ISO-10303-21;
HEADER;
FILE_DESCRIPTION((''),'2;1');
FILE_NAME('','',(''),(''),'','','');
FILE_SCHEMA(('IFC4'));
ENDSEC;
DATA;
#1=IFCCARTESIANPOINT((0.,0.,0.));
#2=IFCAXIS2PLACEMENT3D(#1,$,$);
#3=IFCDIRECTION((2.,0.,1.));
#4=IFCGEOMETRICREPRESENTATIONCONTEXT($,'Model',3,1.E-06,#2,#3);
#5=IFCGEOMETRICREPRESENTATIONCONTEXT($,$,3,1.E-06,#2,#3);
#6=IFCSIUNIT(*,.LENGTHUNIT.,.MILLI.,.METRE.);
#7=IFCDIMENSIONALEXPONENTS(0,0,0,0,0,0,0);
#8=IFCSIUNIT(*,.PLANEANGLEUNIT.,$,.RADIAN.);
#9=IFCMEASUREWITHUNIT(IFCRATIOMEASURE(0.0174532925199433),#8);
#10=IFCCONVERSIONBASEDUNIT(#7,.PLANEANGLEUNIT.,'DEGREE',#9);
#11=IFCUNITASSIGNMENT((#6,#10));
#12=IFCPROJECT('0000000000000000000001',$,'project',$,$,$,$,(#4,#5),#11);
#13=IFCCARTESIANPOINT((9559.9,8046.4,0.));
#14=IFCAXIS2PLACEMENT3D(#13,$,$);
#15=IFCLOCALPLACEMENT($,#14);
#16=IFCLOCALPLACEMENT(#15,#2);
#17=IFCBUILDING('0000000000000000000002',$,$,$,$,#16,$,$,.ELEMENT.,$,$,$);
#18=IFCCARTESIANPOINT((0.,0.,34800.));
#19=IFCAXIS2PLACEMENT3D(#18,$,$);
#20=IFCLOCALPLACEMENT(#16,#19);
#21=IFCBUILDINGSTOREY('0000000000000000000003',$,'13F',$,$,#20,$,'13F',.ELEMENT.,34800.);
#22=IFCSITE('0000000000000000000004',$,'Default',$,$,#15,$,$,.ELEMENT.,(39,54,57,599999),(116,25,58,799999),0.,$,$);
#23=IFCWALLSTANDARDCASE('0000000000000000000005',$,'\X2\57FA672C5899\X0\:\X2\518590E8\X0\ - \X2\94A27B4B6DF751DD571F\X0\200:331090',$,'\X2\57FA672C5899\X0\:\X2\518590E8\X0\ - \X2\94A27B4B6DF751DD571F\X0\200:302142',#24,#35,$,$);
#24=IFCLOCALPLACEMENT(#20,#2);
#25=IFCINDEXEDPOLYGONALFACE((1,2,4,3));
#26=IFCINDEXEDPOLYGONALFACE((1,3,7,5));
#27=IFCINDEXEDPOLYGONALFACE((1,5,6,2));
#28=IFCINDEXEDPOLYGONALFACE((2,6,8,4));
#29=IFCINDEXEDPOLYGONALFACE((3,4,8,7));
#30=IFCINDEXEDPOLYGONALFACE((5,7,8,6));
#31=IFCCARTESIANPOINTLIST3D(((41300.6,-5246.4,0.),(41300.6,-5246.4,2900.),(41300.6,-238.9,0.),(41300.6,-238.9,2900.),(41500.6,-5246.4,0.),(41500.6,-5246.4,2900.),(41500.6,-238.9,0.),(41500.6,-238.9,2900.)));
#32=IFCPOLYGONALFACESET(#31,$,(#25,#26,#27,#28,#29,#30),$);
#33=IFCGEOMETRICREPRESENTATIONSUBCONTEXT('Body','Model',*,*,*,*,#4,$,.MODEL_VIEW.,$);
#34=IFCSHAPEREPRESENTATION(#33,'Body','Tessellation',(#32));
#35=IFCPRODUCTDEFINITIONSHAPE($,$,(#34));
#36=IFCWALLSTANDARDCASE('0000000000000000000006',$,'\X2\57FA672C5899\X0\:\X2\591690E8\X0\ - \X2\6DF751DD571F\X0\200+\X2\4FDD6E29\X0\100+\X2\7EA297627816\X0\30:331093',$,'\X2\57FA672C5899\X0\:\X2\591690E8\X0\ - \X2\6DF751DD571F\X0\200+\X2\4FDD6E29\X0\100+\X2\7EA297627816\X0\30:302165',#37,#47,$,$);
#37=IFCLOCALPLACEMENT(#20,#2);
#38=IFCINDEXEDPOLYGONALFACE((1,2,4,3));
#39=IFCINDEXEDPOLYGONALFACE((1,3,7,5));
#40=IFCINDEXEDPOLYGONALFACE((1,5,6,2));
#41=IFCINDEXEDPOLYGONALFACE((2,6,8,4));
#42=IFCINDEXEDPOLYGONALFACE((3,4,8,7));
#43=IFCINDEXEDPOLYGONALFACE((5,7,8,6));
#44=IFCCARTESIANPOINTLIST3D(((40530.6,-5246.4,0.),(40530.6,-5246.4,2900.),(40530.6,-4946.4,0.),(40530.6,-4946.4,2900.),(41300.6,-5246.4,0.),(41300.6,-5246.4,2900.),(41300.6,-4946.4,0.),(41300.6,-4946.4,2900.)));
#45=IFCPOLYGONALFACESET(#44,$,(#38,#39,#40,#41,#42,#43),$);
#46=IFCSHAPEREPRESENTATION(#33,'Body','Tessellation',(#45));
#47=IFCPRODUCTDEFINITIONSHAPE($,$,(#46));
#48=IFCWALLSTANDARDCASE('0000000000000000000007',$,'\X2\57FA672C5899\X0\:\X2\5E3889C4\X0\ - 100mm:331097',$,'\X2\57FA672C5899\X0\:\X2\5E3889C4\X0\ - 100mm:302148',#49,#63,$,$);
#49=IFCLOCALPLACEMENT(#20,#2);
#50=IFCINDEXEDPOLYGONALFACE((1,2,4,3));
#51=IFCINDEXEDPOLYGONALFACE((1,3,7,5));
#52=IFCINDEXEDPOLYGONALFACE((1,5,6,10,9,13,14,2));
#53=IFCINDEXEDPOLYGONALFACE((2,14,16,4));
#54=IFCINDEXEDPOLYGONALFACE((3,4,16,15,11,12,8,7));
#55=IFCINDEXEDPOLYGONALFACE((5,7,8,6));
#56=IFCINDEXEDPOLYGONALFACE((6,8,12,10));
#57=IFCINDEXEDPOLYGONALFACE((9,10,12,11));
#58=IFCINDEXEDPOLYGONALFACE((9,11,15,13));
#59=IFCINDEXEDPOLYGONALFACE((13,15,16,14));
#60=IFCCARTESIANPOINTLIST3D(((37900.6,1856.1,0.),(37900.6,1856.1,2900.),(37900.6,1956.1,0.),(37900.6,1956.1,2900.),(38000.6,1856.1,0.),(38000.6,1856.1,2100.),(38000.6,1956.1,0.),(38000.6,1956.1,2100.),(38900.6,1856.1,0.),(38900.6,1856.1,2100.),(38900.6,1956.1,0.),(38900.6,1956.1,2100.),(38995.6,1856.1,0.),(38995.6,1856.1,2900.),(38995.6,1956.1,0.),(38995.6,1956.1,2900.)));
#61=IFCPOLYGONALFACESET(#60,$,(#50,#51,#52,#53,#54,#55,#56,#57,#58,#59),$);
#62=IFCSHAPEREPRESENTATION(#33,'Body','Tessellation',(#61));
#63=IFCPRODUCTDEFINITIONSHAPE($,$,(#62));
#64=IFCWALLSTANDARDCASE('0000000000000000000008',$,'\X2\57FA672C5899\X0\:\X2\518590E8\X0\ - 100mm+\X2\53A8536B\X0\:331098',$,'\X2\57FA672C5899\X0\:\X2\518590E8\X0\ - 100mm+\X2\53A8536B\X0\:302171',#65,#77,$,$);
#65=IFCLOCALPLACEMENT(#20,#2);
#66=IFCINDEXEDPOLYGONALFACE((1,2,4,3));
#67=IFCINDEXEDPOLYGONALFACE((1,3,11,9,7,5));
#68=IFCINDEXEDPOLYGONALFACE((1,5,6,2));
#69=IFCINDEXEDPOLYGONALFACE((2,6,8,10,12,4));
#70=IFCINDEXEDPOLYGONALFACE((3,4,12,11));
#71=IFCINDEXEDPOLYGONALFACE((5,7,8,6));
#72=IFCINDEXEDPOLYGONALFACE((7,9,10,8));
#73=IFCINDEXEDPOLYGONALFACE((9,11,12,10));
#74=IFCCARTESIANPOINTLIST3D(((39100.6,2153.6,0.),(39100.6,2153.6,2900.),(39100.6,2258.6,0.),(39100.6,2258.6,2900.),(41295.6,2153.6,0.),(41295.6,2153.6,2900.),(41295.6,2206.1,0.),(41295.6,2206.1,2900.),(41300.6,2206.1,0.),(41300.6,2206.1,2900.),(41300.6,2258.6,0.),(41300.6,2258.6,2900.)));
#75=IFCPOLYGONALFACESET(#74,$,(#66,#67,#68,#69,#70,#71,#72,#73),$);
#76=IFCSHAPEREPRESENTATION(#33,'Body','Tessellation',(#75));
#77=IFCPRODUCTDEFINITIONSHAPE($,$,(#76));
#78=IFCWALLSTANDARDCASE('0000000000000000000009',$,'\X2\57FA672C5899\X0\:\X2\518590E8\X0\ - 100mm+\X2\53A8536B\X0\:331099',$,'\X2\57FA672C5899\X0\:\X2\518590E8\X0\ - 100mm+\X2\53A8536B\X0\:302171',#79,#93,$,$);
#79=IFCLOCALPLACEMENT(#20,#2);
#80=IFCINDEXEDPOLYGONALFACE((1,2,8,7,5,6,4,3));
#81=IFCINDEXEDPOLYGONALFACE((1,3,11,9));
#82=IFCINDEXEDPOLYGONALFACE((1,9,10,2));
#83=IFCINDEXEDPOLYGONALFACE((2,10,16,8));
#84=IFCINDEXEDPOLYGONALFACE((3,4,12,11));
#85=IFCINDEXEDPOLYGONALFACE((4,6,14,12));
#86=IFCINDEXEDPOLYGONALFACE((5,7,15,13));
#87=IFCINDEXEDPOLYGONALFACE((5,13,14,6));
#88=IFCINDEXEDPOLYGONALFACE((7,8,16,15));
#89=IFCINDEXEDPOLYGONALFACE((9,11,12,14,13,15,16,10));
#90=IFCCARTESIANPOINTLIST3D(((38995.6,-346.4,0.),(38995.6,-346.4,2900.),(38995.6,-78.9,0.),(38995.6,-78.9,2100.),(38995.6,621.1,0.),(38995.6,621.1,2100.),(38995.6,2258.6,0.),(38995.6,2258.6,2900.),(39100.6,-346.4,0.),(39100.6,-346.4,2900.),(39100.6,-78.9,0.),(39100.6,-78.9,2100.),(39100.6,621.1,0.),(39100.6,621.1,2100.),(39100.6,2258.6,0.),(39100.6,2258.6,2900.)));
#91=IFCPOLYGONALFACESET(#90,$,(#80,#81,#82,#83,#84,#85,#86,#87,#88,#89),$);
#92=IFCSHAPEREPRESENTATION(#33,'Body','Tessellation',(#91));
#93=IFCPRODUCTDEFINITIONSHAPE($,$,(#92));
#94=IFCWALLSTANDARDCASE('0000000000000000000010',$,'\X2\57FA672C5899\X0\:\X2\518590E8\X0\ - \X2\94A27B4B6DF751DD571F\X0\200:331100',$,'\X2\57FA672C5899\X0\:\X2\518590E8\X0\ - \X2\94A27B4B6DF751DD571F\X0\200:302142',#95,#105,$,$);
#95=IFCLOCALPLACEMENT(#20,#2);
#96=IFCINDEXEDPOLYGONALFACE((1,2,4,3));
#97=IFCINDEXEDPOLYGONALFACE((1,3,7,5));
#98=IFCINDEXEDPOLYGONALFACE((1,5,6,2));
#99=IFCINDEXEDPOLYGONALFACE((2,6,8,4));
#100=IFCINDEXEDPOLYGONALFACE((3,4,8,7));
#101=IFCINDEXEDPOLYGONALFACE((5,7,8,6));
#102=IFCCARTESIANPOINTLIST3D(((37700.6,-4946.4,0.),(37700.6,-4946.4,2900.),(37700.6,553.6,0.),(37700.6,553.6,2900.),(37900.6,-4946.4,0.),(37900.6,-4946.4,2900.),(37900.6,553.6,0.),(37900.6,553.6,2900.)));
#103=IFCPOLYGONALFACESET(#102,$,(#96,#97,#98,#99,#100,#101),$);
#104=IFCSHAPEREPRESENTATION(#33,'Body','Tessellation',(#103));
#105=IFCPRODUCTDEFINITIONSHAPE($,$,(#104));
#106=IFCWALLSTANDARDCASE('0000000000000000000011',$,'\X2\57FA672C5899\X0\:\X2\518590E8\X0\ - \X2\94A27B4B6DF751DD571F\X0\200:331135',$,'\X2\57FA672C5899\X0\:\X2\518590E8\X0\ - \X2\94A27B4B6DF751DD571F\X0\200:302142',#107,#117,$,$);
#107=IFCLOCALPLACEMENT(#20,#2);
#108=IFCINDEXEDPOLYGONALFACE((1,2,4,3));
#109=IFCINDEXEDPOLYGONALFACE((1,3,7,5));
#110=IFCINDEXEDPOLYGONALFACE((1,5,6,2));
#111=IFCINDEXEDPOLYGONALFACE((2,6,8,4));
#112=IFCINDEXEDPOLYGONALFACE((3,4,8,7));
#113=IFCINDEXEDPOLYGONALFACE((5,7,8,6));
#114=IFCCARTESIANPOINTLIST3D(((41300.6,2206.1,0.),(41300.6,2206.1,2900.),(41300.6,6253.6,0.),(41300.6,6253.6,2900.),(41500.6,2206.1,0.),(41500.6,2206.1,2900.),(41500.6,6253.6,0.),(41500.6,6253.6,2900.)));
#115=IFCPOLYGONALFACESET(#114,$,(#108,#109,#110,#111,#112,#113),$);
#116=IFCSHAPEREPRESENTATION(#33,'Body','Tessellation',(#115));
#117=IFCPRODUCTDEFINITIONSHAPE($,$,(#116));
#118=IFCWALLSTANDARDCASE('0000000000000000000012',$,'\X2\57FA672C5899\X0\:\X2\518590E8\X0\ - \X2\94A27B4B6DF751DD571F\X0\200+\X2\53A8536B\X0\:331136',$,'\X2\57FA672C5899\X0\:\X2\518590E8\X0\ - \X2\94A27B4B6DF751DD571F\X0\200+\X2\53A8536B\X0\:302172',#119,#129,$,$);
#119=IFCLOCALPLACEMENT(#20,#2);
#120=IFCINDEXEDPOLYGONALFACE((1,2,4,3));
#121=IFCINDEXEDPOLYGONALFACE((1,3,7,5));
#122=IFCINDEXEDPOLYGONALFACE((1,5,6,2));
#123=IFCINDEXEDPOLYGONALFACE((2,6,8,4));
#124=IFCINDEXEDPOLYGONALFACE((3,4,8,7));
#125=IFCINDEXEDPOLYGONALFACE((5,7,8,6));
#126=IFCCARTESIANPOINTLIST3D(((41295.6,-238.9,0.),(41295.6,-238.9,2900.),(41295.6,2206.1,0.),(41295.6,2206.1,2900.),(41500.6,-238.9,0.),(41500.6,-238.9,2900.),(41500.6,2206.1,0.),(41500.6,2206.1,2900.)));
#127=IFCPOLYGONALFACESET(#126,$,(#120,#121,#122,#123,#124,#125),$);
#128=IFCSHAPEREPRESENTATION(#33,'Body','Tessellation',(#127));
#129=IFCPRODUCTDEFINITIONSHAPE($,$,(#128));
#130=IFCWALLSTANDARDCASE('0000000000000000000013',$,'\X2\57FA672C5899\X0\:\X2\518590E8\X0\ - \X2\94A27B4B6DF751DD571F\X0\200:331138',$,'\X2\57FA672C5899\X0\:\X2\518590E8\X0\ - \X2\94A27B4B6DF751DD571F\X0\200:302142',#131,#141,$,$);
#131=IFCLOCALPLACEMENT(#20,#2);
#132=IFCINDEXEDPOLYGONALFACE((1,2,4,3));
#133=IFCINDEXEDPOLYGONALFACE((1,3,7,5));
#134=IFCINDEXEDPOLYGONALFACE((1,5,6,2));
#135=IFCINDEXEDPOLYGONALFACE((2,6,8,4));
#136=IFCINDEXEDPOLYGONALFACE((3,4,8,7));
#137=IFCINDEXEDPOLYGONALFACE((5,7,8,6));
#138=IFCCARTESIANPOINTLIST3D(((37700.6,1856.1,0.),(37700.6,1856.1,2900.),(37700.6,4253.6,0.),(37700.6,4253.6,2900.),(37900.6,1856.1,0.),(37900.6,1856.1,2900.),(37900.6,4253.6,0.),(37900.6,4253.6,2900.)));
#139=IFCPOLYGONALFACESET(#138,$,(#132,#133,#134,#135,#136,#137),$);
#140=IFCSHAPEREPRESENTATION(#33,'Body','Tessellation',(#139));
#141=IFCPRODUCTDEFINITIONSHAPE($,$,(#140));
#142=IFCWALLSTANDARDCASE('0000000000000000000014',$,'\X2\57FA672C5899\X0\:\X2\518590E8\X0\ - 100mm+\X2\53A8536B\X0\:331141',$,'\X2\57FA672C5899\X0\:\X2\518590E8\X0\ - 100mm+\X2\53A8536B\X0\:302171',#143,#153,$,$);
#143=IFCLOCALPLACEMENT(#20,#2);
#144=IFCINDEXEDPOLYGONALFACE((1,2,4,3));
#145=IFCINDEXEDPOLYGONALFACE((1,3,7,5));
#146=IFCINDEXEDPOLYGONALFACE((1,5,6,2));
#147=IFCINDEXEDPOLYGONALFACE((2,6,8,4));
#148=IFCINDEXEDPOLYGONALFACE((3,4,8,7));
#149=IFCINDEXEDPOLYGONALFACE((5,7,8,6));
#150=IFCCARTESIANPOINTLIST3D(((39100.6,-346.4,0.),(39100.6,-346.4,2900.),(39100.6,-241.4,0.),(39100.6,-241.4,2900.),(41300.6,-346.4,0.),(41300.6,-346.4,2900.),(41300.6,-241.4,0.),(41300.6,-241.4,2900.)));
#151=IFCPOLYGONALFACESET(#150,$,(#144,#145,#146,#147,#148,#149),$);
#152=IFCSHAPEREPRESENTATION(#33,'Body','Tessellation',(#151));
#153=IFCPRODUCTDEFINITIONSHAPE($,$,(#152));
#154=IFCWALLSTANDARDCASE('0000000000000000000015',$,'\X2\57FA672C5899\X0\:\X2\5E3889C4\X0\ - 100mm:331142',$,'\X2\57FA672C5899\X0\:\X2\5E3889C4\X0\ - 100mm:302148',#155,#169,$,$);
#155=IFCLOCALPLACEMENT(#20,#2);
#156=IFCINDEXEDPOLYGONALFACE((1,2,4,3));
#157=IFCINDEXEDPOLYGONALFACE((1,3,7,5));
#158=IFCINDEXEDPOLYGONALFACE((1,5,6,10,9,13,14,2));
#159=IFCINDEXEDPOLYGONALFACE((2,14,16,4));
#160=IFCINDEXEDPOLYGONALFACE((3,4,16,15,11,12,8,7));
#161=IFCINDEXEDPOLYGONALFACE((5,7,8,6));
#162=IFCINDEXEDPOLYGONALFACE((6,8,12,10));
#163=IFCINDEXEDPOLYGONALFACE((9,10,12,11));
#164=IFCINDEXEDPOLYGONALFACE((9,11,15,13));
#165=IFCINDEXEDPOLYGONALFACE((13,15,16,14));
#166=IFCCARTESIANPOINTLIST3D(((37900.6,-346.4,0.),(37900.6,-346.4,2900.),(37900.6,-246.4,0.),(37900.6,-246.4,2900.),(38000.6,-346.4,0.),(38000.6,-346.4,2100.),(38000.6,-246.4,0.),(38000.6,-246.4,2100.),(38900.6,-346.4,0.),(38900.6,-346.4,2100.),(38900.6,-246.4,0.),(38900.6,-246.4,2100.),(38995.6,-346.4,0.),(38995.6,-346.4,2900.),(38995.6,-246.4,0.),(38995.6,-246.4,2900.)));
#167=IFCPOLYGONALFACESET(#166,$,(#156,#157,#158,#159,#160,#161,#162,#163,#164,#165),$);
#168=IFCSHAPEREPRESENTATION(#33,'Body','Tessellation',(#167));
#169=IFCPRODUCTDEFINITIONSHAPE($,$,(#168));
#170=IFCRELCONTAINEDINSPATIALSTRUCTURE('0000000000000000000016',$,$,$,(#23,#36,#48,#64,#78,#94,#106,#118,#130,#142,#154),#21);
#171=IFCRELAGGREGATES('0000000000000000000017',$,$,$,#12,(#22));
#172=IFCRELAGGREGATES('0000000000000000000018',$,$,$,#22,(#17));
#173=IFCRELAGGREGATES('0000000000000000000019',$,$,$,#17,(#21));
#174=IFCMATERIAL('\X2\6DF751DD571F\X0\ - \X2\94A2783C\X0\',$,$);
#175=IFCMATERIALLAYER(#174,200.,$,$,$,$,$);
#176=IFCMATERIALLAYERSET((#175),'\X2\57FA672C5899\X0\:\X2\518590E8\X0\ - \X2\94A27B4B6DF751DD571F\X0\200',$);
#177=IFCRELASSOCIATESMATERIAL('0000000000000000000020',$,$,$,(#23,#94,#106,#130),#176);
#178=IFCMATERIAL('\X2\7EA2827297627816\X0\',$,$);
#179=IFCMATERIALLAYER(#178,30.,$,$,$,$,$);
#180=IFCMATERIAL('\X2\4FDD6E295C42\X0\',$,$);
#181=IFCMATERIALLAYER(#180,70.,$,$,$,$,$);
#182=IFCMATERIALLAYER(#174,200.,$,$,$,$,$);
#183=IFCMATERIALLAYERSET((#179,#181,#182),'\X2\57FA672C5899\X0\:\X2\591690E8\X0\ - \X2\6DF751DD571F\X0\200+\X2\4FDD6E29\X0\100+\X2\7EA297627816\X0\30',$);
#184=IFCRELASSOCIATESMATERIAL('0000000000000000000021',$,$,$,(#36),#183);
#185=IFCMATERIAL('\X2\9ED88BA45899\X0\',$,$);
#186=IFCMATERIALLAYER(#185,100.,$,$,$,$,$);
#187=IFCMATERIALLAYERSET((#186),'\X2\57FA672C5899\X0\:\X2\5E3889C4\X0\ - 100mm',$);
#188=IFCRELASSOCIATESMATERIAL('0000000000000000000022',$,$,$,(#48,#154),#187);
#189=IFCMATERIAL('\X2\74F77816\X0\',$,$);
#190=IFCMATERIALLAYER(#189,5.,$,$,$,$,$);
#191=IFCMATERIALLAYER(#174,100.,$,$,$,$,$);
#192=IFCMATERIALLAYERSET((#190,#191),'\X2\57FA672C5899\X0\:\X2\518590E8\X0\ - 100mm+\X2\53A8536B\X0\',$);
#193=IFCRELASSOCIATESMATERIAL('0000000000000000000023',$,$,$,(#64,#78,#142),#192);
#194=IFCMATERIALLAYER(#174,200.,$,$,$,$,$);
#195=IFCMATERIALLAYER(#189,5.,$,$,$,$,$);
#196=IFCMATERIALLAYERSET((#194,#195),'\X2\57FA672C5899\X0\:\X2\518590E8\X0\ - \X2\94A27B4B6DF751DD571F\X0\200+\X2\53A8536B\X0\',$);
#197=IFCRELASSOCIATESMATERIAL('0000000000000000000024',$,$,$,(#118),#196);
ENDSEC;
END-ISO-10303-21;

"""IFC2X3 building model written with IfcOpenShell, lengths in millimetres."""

from ifc_helpers import new_model, entity, si_unit, converted_unit, direction, frame, frame_2d, origin, place, context, subcontext, project, spatial, polyline, rectangle, outline, extrude, material, layer, layer_set, layer_usage, element, save


model = new_model("IFC2X3")

# Units and contexts
model_context = context("Model", 3, precision=1e-06, world=origin(), true_north=direction((2.0, 0.0, 1.0)))
context_of_model = context(None, 3, precision=1e-06, world=origin(), true_north=direction((2.0, 0.0, 1.0)))
body_context = subcontext(model_context, "Body", "Model", "MODEL_VIEW")
ifc_project = project(units=[si_unit("LENGTHUNIT", "METRE", prefix="MILLI"), converted_unit("PLANEANGLEUNIT", "DEGREE", entity("IfcRatioMeasure", 0.0174532925199433), si_unit("PLANEANGLEUNIT", "RADIAN"), dimensions=[0, 0, 0, 0, 0, 0, 0])], contexts=[model_context, context_of_model])

# Site, building, storey
site_placement = place(None, frame((9559.9, 8046.4, 0.0)))
site = spatial("IfcSite", under=ifc_project, at=site_placement, Name="Default", CompositionType="ELEMENT", RefLatitude=(39, 54, 57, 599999), RefLongitude=(116, 25, 58, 799999), RefElevation=0.0)
building_placement = place(site_placement, origin())
building = spatial("IfcBuilding", under=site, at=building_placement, CompositionType="ELEMENT")
storey_placement = place(building_placement, frame((0.0, 0.0, 34800.0)))
storey = spatial("IfcBuildingStorey", under=building, at=storey_placement, Name="13F", LongName="13F", CompositionType="ELEMENT", Elevation=34800.0)

# Walls
ifc_material_1 = material(Name="混凝土 - 钢砼")
ifc_layer_1 = layer(ifc_material_1, 200.0)
ifc_layer_set_1 = layer_set([ifc_layer_1], Name="基本墙:内部 - 钢筋混凝土200")
ifc_layer_usage_1 = layer_usage(ifc_layer_set_1, "AXIS2", "POSITIVE", -100.0)
wall_1_placement = place(storey_placement, frame((41400.6, -5246.4, 0.0), z_axis=(0.0, 0.0, 1.0), x_axis=(0.0, 1.0, 0.0)))
element("IfcWallStandardCase", 1, at=wall_1_placement, inside=storey, material=ifc_layer_usage_1, Name="基本墙:内部 - 钢筋混凝土200:331090", ObjectType="基本墙:内部 - 钢筋混凝土200:302142", context=body_context, shape_type="SweptSolid", body=[
    extrude(rectangle(XDim=5007.5, YDim=200.0, at=frame_2d((2503.8, 0.0), x_axis=(-1.0, 0.0))), origin(), (0.0, 0.0, 1.0), 2900.0),
])
ifc_material_2 = material(Name="红色面砖")
ifc_layer_2 = layer(ifc_material_2, 30.0)
ifc_material_3 = material(Name="保温层")
ifc_layer_3 = layer(ifc_material_3, 70.0)
ifc_layer_4 = layer(ifc_material_1, 200.0)
ifc_layer_set_2 = layer_set([ifc_layer_2, ifc_layer_3, ifc_layer_4], Name="基本墙:外部 - 混凝土200+保温100+红面砖30")
ifc_layer_usage_2 = layer_usage(ifc_layer_set_2, "AXIS2", "NEGATIVE", 150.0)
wall_2_placement = place(storey_placement, frame((41300.6, -5096.4, 0.0), z_axis=(0.0, 0.0, 1.0), x_axis=(-1.0, 0.0, 0.0)))
element("IfcWallStandardCase", 2, at=wall_2_placement, inside=storey, material=ifc_layer_usage_2, Name="基本墙:外部 - 混凝土200+保温100+红面砖30:331093", ObjectType="基本墙:外部 - 混凝土200+保温100+红面砖30:302165", context=body_context, shape_type="SweptSolid", body=[
    extrude(rectangle(XDim=770.0, YDim=300.0, at=frame_2d((385.0, 0.0), x_axis=(-1.0, 0.0))), origin(), (0.0, 0.0, 1.0), 2900.0),
])

# Wall, opening
ifc_material_4 = material(Name="默认墙")
ifc_layer_5 = layer(ifc_material_4, 100.0)
ifc_layer_set_3 = layer_set([ifc_layer_5], Name="基本墙:常规 - 100mm")
ifc_layer_usage_3 = layer_usage(ifc_layer_set_3, "AXIS2", "POSITIVE", -50.0)
wall_3_placement = place(storey_placement, frame((38995.6, 1906.1, 0.0), z_axis=(0.0, 0.0, 1.0), x_axis=(-1.0, 0.0, 0.0)))
wall_3 = element("IfcWallStandardCase", 3, at=wall_3_placement, inside=storey, material=ifc_layer_usage_3, Name="基本墙:常规 - 100mm:331097", ObjectType="基本墙:常规 - 100mm:302148", context=body_context, shape_type="SweptSolid", body=[
    extrude(rectangle(XDim=1095.0, YDim=100.0, at=frame_2d((547.5, 0.0), x_axis=(-1.0, 0.0))), origin(), (0.0, 0.0, 1.0), 2900.0),
])
opening_1_placement = place(wall_3_placement, frame((995.0, 50.0, 0.0)))
element("IfcOpeningElement", 4, at=opening_1_placement, cuts=wall_3, ObjectType="Opening", context=body_context, shape_type="SweptSolid", body=[
    extrude(rectangle(XDim=2100.0, YDim=900.0, at=frame_2d((1050.0, 450.0), x_axis=(1.0, 0.0))), frame((0.0, 0.0, 0.0), z_axis=(0.0, -1.0, 0.0), x_axis=(0.0, 0.0, 1.0)), (0.0, 0.0, 1.0), 100.0),
])

# Wall
ifc_material_5 = material(Name="瓷砖")
ifc_layer_6 = layer(ifc_material_5, 5.0)
ifc_layer_7 = layer(ifc_material_1, 100.0)
ifc_layer_set_4 = layer_set([ifc_layer_6, ifc_layer_7], Name="基本墙:内部 - 100mm+厨卫")
ifc_layer_usage_4 = layer_usage(ifc_layer_set_4, "AXIS2", "NEGATIVE", 52.5)
wall_4_placement = place(storey_placement, frame((41300.6, 2206.1, 0.0), z_axis=(0.0, 0.0, 1.0), x_axis=(-1.0, 0.0, 0.0)))
element("IfcWallStandardCase", 5, at=wall_4_placement, inside=storey, material=ifc_layer_usage_4, Name="基本墙:内部 - 100mm+厨卫:331098", ObjectType="基本墙:内部 - 100mm+厨卫:302171", context=body_context, shape_type="SweptSolid", body=[
    extrude(outline(polyline([(2200.0, -52.5), (2200.0, 52.5), (5.0, 52.5), (5.0, 0.0), (0.0, 0.0), (0.0, -52.5), (2200.0, -52.5)])), origin(), (0.0, 0.0, 1.0), 2900.0),
])

# Wall, opening
ifc_layer_usage_5 = layer_usage(ifc_layer_set_4, "AXIS2", "NEGATIVE", 52.5)
wall_5_placement = place(storey_placement, frame((39048.1, 2258.6, 0.0), z_axis=(0.0, 0.0, 1.0), x_axis=(0.0, -1.0, 0.0)))
wall_5 = element("IfcWallStandardCase", 6, at=wall_5_placement, inside=storey, material=ifc_layer_usage_5, Name="基本墙:内部 - 100mm+厨卫:331099", ObjectType="基本墙:内部 - 100mm+厨卫:302171", context=body_context, shape_type="SweptSolid", body=[
    extrude(rectangle(XDim=2605.0, YDim=105.0, at=frame_2d((1302.5, 0.0), x_axis=(-1.0, 0.0))), origin(), (0.0, 0.0, 1.0), 2900.0),
])
opening_2_placement = place(wall_5_placement, frame((1637.5, -52.5, 0.0)))
element("IfcOpeningElement", 7, at=opening_2_placement, cuts=wall_5, ObjectType="Opening", context=body_context, shape_type="SweptSolid", body=[
    extrude(rectangle(XDim=2100.0, YDim=700.0, at=frame_2d((1050.0, 350.0), x_axis=(1.0, 0.0))), frame((0.0, 0.0, 0.0), z_axis=(0.0, 1.0, 0.0), x_axis=(0.0, 0.0, 1.0)), (0.0, 0.0, 1.0), 105.0),
])

# Walls
ifc_layer_usage_6 = layer_usage(ifc_layer_set_1, "AXIS2", "NEGATIVE", 100.0)
wall_6_placement = place(storey_placement, frame((37800.6, 553.6, 0.0), z_axis=(0.0, 0.0, 1.0), x_axis=(0.0, -1.0, 0.0)))
element("IfcWallStandardCase", 8, at=wall_6_placement, inside=storey, material=ifc_layer_usage_6, Name="基本墙:内部 - 钢筋混凝土200:331100", ObjectType="基本墙:内部 - 钢筋混凝土200:302142", context=body_context, shape_type="SweptSolid", body=[
    extrude(rectangle(XDim=5500.0, YDim=200.0, at=frame_2d((2750.0, 0.0), x_axis=(-1.0, 0.0))), origin(), (0.0, 0.0, 1.0), 2900.0),
])
ifc_layer_usage_7 = layer_usage(ifc_layer_set_1, "AXIS2", "POSITIVE", -100.0)
wall_7_placement = place(storey_placement, frame((41400.6, 2206.1, 0.0), z_axis=(0.0, 0.0, 1.0), x_axis=(0.0, 1.0, 0.0)))
element("IfcWallStandardCase", 9, at=wall_7_placement, inside=storey, material=ifc_layer_usage_7, Name="基本墙:内部 - 钢筋混凝土200:331135", ObjectType="基本墙:内部 - 钢筋混凝土200:302142", context=body_context, shape_type="SweptSolid", body=[
    extrude(rectangle(XDim=4047.5, YDim=200.0, at=frame_2d((2023.8, 0.0), x_axis=(-1.0, 0.0))), origin(), (0.0, 0.0, 1.0), 2900.0),
])
ifc_layer_8 = layer(ifc_material_1, 200.0)
ifc_layer_9 = layer(ifc_material_5, 5.0)
ifc_layer_set_5 = layer_set([ifc_layer_8, ifc_layer_9], Name="基本墙:内部 - 钢筋混凝土200+厨卫")
ifc_layer_usage_8 = layer_usage(ifc_layer_set_5, "AXIS2", "POSITIVE", -102.5)
wall_8_placement = place(storey_placement, frame((41398.1, -238.9, 0.0), z_axis=(0.0, 0.0, 1.0), x_axis=(0.0, 1.0, 0.0)))
element("IfcWallStandardCase", 10, at=wall_8_placement, inside=storey, material=ifc_layer_usage_8, Name="基本墙:内部 - 钢筋混凝土200+厨卫:331136", ObjectType="基本墙:内部 - 钢筋混凝土200+厨卫:302172", context=body_context, shape_type="SweptSolid", body=[
    extrude(rectangle(XDim=2445.0, YDim=205.0, at=frame_2d((1222.5, 0.0), x_axis=(-1.0, 0.0))), origin(), (0.0, 0.0, 1.0), 2900.0),
])
ifc_layer_usage_9 = layer_usage(ifc_layer_set_1, "AXIS2", "POSITIVE", -100.0)
wall_9_placement = place(storey_placement, frame((37800.6, 4253.6, 0.0), z_axis=(0.0, 0.0, 1.0), x_axis=(0.0, -1.0, 0.0)))
element("IfcWallStandardCase", 11, at=wall_9_placement, inside=storey, material=ifc_layer_usage_9, Name="基本墙:内部 - 钢筋混凝土200:331138", ObjectType="基本墙:内部 - 钢筋混凝土200:302142", context=body_context, shape_type="SweptSolid", body=[
    extrude(rectangle(XDim=2397.5, YDim=200.0, at=frame_2d((1198.8, 0.0), x_axis=(-1.0, 0.0))), origin(), (0.0, 0.0, 1.0), 2900.0),
])
ifc_layer_usage_10 = layer_usage(ifc_layer_set_4, "AXIS2", "POSITIVE", -52.5)
wall_10_placement = place(storey_placement, frame((41300.6, -293.9, 0.0), z_axis=(0.0, 0.0, 1.0), x_axis=(-1.0, 0.0, 0.0)))
element("IfcWallStandardCase", 12, at=wall_10_placement, inside=storey, material=ifc_layer_usage_10, Name="基本墙:内部 - 100mm+厨卫:331141", ObjectType="基本墙:内部 - 100mm+厨卫:302171", context=body_context, shape_type="SweptSolid", body=[
    extrude(rectangle(XDim=2200.0, YDim=105.0, at=frame_2d((1100.0, 0.0), x_axis=(-1.0, 0.0))), origin(), (0.0, 0.0, 1.0), 2900.0),
])

# Wall, opening
ifc_layer_usage_11 = layer_usage(ifc_layer_set_3, "AXIS2", "POSITIVE", -50.0)
wall_11_placement = place(storey_placement, frame((38995.6, -296.4, 0.0), z_axis=(0.0, 0.0, 1.0), x_axis=(-1.0, 0.0, 0.0)))
wall_11 = element("IfcWallStandardCase", 13, at=wall_11_placement, inside=storey, material=ifc_layer_usage_11, Name="基本墙:常规 - 100mm:331142", ObjectType="基本墙:常规 - 100mm:302148", context=body_context, shape_type="SweptSolid", body=[
    extrude(rectangle(XDim=1095.0, YDim=100.0, at=frame_2d((547.5, 0.0), x_axis=(-1.0, 0.0))), origin(), (0.0, 0.0, 1.0), 2900.0),
])
opening_3_placement = place(wall_11_placement, frame((95.0, -50.0, 0.0)))
element("IfcOpeningElement", 14, at=opening_3_placement, cuts=wall_11, ObjectType="Opening", context=body_context, shape_type="SweptSolid", body=[
    extrude(rectangle(XDim=2100.0, YDim=900.0, at=frame_2d((1050.0, 450.0), x_axis=(1.0, 0.0))), frame((0.0, 0.0, 0.0), z_axis=(0.0, 1.0, 0.0), x_axis=(0.0, 0.0, 1.0)), (0.0, 0.0, 1.0), 100.0),
])

save(model, "model.ifc")
